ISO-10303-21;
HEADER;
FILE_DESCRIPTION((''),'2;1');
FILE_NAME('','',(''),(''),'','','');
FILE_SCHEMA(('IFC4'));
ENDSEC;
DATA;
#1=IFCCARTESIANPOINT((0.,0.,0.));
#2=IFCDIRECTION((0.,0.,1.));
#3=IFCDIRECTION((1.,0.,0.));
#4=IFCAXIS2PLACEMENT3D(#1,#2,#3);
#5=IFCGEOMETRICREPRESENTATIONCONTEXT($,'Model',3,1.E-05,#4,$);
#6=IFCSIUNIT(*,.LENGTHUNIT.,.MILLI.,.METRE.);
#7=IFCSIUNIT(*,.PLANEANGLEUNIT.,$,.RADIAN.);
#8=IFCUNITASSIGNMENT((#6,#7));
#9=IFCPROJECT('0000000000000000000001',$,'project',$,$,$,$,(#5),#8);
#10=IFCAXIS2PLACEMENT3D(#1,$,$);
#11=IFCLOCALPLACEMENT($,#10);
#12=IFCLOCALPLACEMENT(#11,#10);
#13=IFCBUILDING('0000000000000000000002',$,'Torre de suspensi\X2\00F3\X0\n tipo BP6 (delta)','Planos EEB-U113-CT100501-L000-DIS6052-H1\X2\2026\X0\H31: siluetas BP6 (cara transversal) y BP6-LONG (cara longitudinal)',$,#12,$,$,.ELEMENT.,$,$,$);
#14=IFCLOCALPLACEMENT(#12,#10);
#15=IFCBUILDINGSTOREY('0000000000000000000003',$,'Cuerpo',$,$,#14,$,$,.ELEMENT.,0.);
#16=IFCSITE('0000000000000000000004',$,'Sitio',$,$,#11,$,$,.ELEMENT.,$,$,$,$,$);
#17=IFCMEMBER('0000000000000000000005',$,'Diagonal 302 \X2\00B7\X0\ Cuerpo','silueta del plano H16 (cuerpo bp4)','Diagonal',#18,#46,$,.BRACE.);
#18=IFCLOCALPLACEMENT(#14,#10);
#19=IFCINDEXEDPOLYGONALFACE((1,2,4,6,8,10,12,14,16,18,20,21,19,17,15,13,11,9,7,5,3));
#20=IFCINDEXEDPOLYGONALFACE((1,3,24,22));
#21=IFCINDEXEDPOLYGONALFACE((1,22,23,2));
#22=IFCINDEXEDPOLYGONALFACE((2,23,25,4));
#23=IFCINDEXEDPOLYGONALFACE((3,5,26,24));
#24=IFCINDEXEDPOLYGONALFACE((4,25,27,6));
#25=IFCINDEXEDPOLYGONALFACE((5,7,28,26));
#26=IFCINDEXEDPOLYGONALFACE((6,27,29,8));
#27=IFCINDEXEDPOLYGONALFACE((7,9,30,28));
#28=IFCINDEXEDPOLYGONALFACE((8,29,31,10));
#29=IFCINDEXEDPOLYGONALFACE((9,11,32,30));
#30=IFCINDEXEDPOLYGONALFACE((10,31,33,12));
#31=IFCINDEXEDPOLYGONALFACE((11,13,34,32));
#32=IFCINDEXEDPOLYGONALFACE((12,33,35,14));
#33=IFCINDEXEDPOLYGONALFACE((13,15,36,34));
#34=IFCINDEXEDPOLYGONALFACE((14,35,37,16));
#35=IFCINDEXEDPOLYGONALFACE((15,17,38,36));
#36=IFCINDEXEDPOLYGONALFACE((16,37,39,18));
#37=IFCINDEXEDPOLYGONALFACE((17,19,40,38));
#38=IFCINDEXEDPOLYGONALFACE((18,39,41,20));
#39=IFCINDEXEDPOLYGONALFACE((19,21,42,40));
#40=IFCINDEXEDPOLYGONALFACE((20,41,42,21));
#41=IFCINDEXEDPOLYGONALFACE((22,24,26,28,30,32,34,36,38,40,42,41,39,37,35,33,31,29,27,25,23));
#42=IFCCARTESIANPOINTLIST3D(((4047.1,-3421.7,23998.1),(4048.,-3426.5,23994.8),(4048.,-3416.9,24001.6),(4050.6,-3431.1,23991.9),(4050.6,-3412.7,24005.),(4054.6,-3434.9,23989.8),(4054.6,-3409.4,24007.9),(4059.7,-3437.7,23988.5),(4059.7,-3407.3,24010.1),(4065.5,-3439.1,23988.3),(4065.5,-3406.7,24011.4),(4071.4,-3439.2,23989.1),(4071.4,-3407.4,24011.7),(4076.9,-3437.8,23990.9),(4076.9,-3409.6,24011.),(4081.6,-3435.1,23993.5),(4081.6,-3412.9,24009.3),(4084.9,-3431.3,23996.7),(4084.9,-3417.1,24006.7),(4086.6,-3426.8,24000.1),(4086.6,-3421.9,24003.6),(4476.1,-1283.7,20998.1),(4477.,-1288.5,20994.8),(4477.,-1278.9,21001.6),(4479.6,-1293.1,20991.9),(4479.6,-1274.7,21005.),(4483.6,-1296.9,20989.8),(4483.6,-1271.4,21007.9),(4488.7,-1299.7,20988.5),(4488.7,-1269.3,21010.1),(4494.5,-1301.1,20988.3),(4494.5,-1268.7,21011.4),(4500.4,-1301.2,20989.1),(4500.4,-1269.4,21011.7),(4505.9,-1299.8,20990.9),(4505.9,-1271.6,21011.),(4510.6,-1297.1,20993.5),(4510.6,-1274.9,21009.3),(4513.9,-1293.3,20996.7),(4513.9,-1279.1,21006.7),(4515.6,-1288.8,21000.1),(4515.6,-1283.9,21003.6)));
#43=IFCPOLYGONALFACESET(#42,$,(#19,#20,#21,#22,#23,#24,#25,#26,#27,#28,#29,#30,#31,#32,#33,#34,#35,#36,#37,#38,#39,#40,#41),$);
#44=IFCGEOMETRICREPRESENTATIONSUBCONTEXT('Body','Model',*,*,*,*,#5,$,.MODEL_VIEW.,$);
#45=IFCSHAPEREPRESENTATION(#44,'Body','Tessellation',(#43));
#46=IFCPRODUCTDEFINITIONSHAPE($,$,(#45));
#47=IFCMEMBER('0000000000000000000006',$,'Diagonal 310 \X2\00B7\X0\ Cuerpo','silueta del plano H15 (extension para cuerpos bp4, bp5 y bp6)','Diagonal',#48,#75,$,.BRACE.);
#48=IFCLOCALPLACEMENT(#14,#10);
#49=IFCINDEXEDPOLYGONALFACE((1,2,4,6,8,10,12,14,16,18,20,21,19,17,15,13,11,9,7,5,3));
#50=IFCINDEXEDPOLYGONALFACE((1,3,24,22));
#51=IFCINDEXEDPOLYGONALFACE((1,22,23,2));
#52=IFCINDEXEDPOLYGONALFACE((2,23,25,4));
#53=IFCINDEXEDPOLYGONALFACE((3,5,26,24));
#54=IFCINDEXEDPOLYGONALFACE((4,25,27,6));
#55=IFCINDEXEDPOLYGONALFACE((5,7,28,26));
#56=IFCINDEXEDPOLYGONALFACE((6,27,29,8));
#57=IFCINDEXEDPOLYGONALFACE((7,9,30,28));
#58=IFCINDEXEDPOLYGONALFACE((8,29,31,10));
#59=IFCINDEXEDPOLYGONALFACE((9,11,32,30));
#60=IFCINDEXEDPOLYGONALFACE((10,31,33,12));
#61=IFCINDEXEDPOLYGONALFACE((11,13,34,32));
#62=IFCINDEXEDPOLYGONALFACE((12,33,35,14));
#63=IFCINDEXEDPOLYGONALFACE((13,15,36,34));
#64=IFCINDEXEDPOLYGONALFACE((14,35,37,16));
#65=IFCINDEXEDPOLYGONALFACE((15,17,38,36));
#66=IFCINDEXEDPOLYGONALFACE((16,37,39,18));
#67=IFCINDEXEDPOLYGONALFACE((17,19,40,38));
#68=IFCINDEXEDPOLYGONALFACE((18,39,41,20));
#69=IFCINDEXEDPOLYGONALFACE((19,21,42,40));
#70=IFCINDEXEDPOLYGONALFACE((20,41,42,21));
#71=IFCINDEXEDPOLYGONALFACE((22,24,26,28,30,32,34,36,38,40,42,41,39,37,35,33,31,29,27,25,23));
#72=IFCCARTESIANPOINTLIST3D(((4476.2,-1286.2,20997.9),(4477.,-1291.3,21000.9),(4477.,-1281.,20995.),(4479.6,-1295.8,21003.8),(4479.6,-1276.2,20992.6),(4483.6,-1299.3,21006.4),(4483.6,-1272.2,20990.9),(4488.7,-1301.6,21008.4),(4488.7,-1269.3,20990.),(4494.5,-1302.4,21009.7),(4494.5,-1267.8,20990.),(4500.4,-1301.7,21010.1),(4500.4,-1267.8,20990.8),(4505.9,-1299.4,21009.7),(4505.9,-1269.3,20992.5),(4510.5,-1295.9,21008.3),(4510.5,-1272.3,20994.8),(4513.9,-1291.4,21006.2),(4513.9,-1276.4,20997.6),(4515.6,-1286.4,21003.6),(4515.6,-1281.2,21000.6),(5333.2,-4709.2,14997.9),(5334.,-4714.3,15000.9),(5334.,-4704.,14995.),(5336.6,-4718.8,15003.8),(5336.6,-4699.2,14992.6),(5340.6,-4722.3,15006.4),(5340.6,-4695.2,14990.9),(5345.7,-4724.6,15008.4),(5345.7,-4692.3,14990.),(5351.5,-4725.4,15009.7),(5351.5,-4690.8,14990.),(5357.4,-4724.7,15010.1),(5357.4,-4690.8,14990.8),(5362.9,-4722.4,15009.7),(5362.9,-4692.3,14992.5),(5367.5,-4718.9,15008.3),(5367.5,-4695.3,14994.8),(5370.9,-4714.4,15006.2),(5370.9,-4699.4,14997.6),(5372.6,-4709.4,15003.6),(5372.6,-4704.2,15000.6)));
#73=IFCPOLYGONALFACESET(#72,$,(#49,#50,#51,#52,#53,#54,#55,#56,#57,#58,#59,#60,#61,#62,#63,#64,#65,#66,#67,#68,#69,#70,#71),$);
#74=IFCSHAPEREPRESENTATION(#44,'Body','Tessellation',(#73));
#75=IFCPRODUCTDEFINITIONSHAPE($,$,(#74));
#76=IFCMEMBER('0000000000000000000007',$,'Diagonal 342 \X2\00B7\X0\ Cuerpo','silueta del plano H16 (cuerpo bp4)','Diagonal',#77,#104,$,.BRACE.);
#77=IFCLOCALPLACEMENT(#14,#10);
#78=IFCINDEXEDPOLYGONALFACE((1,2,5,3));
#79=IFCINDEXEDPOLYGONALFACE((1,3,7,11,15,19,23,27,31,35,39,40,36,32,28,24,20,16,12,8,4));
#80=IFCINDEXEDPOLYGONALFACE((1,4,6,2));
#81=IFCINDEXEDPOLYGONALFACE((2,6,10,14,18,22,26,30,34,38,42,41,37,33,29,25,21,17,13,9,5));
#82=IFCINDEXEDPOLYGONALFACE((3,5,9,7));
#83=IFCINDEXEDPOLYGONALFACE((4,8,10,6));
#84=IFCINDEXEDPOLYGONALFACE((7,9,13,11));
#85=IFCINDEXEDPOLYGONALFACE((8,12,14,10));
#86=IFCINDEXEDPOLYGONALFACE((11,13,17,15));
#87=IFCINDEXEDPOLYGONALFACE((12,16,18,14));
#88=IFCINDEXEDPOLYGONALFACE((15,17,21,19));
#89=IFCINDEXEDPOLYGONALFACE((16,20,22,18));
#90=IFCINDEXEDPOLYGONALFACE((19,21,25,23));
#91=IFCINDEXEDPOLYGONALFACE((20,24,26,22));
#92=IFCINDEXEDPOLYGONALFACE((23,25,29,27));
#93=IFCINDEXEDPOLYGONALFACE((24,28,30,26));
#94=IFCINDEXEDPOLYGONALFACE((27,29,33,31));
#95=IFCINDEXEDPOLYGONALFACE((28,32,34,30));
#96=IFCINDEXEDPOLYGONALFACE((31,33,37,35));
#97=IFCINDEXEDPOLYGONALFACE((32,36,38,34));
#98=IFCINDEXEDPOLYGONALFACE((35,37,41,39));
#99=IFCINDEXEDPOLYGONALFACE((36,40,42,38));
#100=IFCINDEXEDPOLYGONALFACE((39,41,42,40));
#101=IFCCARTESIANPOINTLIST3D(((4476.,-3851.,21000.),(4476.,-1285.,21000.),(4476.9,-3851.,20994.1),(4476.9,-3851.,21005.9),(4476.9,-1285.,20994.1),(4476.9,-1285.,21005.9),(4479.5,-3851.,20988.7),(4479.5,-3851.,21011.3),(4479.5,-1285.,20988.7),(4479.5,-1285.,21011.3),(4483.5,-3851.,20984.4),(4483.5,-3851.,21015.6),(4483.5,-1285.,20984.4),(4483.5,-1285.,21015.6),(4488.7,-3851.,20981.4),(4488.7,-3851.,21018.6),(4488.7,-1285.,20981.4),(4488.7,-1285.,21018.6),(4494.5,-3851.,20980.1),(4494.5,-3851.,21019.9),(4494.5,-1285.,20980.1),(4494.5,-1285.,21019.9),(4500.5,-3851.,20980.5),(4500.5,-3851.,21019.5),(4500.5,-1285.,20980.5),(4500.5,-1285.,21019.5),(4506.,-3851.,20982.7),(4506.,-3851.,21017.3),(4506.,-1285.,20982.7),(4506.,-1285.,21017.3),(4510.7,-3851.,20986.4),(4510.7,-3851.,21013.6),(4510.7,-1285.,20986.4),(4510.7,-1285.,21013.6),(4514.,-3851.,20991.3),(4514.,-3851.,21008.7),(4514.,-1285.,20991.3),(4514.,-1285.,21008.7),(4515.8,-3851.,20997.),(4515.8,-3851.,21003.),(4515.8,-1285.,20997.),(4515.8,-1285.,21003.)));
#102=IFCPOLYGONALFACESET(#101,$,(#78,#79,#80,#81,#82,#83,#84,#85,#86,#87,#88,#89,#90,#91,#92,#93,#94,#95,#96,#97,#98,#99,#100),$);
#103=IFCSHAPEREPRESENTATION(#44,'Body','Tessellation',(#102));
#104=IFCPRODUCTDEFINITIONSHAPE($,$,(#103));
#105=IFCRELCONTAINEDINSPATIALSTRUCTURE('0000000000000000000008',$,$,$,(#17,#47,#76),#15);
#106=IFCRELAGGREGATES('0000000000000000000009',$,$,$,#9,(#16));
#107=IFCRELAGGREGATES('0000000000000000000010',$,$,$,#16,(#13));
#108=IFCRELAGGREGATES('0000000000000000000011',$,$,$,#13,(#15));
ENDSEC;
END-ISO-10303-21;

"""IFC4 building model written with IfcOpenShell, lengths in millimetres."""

from ifc_helpers import new_model, si_unit, frame, origin, origin_with_axes, place, context, subcontext, project, spatial, circle, extrude, element, save


model = new_model("IFC4")

# Units and contexts
model_context = context("Model", 3, precision=1e-05, world=origin_with_axes())
body_context = subcontext(model_context, "Body", "Model", "MODEL_VIEW")
ifc_project = project(units=[si_unit("LENGTHUNIT", "METRE", prefix="MILLI"), si_unit("PLANEANGLEUNIT", "RADIAN")], contexts=[model_context])

# Site, building, storey
site_placement = place(None, origin())
site = spatial("IfcSite", under=ifc_project, at=site_placement, Name="Sitio", CompositionType="ELEMENT")
building_placement = place(site_placement, origin())
building = spatial("IfcBuilding", under=site, at=building_placement, Name="Torre de suspensión tipo BP6 (delta)", Description="Planos EEB-U113-CT100501-L000-DIS6052-H1…H31: siluetas BP6 (cara transversal) y BP6-LONG (cara longitudinal)", CompositionType="ELEMENT")
storey_placement = place(building_placement, origin())
storey = spatial("IfcBuildingStorey", under=building, at=storey_placement, Name="Cuerpo", CompositionType="ELEMENT", Elevation=0.0)

# Members
member_1_placement = place(storey_placement, frame((4067.0, -3423.0, 24000.0), z_axis=(0.115671, 0.576469, -0.80889), x_axis=(-0.993288, 0.067132, -0.094198)))
element("IfcMember", 1, at=member_1_placement, inside=storey, Name="Diagonal 302 · Cuerpo", Description="silueta del plano H16 (cuerpo bp4)", ObjectType="Diagonal", PredefinedType="BRACE", context=body_context, shape_type="SweptSolid", body=[
    extrude(circle(Radius=20.0), None, (0.0, 0.0, 1.0), 3708.8),
])
member_2_placement = place(storey_placement, frame((4496.0, -1285.0, 21000.0), z_axis=(0.12312, -0.491761, -0.861982), x_axis=(-0.992392, -0.06101, -0.106941)))
element("IfcMember", 2, at=member_2_placement, inside=storey, Name="Diagonal 310 · Cuerpo", Description="silueta del plano H15 (extension para cuerpos bp4, bp5 y bp6)", ObjectType="Diagonal", PredefinedType="BRACE", context=body_context, shape_type="SweptSolid", body=[
    extrude(circle(Radius=20.0), None, (0.0, 0.0, 1.0), 6960.7),
])
member_3_placement = place(storey_placement, frame((4496.0, -3851.0, 21000.0), z_axis=(0.0, 1.0, 0.0), x_axis=(-1.0, 0.0, 0.0)))
element("IfcMember", 3, at=member_3_placement, inside=storey, Name="Diagonal 342 · Cuerpo", Description="silueta del plano H16 (cuerpo bp4)", ObjectType="Diagonal", PredefinedType="BRACE", context=body_context, shape_type="SweptSolid", body=[
    extrude(circle(Radius=20.0), None, (0.0, 0.0, 1.0), 2566.0),
])

save(model, "model.ifc")
